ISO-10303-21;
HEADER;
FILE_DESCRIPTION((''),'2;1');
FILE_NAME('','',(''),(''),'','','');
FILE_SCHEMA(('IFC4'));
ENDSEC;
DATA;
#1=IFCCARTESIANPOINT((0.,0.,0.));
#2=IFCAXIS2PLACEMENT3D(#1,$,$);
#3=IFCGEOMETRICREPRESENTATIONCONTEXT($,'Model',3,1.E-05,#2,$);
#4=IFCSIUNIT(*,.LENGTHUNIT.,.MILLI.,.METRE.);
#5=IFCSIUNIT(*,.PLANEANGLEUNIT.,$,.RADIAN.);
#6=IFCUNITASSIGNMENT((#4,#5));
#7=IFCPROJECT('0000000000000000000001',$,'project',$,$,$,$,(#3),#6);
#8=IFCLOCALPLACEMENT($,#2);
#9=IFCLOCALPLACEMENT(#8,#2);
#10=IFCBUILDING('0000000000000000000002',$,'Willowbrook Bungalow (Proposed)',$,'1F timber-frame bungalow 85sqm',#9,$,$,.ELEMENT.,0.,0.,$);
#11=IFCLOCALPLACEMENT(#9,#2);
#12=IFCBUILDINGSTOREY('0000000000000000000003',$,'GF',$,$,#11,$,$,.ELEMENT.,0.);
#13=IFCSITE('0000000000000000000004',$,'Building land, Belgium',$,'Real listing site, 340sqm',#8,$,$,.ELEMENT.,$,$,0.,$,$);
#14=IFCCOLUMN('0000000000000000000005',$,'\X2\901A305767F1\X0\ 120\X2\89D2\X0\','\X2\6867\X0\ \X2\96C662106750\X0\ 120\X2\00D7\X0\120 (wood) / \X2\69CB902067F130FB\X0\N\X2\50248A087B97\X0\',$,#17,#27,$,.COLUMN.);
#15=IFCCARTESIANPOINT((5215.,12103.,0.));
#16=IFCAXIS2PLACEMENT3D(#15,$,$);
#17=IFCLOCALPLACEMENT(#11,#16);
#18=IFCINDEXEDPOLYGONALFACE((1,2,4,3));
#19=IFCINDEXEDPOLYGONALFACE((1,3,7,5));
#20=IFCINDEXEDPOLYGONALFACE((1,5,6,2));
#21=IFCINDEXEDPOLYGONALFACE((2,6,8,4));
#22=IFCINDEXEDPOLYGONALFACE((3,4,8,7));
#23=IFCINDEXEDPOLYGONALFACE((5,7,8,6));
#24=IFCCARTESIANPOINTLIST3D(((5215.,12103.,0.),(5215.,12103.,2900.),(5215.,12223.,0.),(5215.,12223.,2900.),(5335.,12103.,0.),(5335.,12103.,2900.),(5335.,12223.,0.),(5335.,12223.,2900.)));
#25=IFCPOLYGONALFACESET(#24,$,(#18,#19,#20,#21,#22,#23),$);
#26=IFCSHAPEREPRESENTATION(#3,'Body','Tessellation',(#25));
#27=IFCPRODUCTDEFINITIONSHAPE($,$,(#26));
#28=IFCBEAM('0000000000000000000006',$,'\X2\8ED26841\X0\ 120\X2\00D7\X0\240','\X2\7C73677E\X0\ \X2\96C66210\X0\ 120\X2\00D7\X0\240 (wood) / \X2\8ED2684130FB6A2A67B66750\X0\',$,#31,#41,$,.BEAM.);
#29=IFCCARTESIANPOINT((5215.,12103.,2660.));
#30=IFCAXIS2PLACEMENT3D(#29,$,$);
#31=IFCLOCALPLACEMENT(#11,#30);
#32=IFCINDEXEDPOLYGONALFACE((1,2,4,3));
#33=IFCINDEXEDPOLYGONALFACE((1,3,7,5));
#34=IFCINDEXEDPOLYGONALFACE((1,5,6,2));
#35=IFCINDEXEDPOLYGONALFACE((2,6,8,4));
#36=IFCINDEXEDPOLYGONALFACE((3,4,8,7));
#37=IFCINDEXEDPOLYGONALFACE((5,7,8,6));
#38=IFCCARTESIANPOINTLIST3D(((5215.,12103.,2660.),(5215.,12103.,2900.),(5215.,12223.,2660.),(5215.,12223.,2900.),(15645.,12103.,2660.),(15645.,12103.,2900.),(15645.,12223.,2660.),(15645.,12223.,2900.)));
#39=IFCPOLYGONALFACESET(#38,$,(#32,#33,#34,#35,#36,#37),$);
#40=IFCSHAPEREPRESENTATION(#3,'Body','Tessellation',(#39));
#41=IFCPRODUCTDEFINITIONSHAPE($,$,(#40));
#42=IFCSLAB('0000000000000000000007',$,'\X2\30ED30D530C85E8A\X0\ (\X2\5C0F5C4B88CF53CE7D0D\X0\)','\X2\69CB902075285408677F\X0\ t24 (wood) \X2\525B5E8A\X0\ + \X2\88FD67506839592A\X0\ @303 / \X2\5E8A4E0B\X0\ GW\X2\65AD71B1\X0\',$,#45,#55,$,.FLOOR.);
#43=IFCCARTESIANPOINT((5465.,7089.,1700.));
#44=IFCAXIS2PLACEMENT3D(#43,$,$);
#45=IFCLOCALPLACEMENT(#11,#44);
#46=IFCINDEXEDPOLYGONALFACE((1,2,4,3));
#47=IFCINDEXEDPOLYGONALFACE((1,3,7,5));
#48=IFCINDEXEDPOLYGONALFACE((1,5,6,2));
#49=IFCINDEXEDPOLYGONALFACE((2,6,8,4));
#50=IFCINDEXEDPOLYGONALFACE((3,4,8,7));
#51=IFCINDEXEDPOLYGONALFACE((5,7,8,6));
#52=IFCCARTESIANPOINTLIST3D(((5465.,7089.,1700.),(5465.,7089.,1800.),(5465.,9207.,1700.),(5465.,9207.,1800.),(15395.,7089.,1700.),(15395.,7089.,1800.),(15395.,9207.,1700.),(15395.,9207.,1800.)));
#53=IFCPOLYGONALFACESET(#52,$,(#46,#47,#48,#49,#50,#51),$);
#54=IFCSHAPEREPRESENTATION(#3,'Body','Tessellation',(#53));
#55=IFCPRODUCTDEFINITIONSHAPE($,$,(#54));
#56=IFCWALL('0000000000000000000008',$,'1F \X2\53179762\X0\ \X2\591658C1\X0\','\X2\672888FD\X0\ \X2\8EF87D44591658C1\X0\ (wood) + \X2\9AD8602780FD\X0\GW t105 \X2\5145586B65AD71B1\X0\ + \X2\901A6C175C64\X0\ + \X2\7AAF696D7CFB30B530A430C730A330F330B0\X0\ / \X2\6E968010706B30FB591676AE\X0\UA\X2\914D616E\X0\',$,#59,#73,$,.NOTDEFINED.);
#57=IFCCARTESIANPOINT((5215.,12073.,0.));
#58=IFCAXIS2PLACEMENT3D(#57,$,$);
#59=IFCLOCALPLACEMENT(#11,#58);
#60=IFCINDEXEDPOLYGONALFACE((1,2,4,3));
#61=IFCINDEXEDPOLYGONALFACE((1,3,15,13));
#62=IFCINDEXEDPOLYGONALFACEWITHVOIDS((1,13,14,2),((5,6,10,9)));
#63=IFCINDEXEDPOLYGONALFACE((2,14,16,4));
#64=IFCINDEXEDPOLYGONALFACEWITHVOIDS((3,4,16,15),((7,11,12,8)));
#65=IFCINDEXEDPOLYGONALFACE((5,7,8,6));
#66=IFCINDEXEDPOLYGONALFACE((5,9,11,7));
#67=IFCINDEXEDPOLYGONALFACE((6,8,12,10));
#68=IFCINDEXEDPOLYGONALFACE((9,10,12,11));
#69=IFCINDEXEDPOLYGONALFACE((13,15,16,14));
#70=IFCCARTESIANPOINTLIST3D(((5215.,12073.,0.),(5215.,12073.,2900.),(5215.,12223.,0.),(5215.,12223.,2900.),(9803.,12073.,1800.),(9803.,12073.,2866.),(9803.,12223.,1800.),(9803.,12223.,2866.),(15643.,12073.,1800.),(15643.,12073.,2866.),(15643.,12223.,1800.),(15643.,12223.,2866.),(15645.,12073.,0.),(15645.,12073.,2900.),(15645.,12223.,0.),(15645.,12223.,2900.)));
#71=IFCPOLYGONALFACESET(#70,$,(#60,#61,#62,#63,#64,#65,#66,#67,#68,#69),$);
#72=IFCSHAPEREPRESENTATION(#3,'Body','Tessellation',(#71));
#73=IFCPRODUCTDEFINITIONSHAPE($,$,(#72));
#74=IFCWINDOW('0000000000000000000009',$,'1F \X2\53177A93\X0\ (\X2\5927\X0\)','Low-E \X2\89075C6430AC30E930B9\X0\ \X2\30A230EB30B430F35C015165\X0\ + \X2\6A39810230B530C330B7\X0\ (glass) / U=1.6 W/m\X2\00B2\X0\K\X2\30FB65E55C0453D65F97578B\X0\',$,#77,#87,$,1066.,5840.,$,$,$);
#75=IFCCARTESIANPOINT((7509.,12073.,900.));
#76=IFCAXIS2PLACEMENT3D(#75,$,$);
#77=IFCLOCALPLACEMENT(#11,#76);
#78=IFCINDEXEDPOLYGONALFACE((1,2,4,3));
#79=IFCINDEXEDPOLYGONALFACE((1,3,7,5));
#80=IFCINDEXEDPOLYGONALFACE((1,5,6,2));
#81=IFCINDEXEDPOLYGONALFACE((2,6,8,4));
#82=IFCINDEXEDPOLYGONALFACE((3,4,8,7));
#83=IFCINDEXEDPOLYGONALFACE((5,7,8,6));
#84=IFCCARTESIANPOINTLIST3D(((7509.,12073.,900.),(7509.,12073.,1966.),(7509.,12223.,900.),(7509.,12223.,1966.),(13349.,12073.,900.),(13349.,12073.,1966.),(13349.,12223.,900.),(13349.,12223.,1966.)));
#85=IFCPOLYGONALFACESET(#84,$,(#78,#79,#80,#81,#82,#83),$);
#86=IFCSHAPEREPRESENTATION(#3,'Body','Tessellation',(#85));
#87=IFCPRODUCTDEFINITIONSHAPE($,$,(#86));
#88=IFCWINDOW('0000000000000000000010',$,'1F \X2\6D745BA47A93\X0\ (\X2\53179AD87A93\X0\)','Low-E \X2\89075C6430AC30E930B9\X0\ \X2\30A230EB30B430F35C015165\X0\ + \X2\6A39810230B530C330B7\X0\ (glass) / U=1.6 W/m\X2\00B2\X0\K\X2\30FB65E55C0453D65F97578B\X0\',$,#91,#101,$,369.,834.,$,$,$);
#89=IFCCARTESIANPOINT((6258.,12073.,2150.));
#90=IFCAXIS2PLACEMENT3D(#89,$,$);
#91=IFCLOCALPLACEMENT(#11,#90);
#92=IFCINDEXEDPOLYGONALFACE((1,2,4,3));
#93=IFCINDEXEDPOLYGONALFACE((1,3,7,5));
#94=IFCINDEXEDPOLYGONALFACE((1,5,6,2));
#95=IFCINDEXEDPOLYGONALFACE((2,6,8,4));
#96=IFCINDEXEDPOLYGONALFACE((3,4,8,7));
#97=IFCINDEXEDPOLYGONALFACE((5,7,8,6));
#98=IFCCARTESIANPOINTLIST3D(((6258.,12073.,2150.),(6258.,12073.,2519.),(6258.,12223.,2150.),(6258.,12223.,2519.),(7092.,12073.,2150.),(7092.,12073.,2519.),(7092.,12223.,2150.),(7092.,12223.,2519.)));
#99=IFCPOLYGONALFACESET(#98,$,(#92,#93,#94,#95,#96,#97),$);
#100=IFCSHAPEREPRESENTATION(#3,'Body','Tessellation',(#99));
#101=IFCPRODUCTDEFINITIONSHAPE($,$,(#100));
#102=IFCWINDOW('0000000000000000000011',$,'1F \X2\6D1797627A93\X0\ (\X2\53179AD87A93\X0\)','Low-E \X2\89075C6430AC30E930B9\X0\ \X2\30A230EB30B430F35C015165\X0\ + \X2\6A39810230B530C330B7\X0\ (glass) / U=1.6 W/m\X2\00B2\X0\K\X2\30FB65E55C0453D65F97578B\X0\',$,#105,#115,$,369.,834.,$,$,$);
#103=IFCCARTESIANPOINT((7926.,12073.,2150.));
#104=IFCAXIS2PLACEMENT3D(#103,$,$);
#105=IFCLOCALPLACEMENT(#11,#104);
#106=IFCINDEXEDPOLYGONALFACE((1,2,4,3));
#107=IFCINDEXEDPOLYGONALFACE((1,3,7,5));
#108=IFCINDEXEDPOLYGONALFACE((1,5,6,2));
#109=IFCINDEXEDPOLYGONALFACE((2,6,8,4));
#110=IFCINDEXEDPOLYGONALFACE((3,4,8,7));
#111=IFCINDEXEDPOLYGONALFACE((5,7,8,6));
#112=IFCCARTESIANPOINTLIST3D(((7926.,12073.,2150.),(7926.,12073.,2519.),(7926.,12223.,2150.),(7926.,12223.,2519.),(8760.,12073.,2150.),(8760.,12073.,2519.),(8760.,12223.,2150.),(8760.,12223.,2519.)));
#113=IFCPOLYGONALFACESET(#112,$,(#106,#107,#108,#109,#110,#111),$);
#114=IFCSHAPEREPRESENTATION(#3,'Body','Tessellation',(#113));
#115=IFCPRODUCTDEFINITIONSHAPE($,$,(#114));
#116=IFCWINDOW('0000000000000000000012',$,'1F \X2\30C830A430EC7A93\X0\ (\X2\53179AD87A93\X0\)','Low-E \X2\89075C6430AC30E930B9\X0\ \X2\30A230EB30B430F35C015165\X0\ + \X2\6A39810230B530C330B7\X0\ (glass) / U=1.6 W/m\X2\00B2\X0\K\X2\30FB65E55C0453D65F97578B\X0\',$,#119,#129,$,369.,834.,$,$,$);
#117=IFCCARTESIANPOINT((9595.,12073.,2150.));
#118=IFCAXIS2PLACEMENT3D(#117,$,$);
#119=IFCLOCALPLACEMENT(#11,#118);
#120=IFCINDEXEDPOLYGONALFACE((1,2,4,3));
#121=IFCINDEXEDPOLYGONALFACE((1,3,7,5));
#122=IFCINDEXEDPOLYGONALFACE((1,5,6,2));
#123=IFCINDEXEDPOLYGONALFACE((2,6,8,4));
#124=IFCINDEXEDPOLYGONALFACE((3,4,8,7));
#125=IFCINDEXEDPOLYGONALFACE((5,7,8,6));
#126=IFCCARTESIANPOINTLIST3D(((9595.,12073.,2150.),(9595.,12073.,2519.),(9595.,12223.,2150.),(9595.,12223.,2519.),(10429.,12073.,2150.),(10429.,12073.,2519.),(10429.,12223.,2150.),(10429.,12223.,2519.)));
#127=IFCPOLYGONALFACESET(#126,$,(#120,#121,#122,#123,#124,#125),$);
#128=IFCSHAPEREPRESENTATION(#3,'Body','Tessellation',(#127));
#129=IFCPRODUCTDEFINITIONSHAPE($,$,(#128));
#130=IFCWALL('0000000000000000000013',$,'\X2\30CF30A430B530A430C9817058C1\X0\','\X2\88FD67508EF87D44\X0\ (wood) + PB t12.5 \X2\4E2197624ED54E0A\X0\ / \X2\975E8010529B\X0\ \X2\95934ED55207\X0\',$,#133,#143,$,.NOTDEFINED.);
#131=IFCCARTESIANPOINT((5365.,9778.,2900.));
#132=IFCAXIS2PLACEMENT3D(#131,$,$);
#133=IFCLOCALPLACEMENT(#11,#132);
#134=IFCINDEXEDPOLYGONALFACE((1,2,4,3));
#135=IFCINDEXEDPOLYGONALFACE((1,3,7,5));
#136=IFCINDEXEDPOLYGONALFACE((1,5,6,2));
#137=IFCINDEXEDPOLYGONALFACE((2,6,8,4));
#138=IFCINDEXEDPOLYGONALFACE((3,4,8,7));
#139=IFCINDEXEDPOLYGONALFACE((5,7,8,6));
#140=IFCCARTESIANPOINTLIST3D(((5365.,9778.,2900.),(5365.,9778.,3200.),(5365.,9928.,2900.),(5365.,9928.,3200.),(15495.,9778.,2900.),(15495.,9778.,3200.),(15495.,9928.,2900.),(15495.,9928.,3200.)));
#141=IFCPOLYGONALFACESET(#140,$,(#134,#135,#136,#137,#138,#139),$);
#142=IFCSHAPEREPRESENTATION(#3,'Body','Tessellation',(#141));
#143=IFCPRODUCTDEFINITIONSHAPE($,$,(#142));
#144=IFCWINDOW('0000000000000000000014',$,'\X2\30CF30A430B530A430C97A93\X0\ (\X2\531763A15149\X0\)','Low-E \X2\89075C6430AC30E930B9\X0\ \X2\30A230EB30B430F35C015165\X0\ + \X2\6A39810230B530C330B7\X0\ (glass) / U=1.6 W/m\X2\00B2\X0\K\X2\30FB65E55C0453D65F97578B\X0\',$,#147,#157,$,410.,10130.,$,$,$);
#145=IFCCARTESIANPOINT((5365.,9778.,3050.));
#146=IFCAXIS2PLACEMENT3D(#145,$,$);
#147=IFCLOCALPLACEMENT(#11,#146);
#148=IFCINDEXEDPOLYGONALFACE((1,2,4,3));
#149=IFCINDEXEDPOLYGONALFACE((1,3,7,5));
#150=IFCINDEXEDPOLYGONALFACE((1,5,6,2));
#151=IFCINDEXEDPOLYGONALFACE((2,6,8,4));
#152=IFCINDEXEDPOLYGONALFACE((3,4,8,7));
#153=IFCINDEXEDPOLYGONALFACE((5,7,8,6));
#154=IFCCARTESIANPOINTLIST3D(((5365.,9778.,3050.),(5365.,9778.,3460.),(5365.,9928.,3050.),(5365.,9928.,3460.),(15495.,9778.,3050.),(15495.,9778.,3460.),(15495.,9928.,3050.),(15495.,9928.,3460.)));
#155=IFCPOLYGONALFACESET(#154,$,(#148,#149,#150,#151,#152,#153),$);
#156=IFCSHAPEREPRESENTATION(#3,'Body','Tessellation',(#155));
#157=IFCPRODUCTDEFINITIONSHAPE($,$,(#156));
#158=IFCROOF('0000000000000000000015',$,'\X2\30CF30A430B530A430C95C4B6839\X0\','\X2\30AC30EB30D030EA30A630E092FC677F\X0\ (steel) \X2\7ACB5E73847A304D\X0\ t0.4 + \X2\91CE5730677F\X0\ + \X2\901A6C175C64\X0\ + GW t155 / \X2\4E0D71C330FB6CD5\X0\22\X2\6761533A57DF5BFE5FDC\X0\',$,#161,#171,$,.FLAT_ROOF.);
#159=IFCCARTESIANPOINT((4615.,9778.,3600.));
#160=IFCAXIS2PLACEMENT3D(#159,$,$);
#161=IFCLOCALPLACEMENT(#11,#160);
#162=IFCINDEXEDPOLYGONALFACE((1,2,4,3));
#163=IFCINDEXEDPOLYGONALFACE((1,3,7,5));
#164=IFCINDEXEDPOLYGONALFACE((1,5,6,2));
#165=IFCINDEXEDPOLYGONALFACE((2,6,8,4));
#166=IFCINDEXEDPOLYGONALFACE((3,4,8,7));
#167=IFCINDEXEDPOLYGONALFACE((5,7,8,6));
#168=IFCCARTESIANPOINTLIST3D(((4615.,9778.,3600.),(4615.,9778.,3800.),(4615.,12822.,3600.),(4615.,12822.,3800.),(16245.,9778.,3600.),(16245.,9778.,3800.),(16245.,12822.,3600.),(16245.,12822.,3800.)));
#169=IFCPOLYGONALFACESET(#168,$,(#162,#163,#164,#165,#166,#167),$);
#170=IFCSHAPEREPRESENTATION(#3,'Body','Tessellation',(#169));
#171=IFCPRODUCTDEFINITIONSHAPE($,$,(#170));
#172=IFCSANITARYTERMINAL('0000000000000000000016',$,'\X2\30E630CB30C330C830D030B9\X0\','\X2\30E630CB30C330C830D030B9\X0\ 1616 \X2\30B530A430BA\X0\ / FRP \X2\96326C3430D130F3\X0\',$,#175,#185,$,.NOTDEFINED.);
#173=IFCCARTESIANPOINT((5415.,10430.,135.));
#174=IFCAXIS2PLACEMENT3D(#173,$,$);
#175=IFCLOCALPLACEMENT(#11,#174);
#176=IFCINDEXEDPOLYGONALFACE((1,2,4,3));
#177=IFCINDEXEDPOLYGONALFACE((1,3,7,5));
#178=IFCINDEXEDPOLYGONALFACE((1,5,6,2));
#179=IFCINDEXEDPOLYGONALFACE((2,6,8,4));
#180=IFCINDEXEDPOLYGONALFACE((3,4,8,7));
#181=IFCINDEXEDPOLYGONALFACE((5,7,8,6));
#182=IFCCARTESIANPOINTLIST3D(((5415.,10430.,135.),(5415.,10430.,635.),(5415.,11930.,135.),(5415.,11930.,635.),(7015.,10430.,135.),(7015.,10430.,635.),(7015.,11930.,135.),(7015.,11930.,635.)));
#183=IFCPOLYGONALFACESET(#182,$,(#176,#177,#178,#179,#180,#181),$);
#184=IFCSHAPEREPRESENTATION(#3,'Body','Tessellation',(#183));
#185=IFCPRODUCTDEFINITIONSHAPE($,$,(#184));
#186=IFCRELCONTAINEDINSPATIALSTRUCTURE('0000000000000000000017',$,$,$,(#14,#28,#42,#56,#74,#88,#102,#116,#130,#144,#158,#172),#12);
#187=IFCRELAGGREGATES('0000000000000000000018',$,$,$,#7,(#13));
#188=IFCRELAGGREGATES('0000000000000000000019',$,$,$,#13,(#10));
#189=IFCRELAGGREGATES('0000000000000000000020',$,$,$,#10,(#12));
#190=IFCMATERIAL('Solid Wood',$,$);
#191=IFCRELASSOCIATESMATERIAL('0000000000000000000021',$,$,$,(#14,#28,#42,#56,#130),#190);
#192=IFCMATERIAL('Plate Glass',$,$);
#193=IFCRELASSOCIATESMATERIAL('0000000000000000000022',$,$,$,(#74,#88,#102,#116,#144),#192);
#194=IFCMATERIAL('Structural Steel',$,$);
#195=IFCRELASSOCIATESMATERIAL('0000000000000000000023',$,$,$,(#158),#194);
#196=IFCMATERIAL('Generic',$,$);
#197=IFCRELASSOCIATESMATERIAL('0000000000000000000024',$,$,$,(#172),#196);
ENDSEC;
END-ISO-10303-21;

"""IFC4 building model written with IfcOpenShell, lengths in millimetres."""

from ifc_helpers import new_model, si_unit, frame, frame_2d, origin, place, context, project, spatial, rectangle, extrude, material, element, fill, save


model = new_model("IFC4")

# Units and contexts
model_context = context("Model", 3, precision=1e-05, world=origin())
ifc_project = project(units=[si_unit("LENGTHUNIT", "METRE", prefix="MILLI"), si_unit("PLANEANGLEUNIT", "RADIAN")], contexts=[model_context])

# Site, building, storey
site_placement = place(None, origin())
site = spatial("IfcSite", under=ifc_project, at=site_placement, Name="Building land, Belgium", ObjectType="Real listing site, 340sqm", CompositionType="ELEMENT", RefElevation=0.0)
building_placement = place(site_placement, origin())
building = spatial("IfcBuilding", under=site, at=building_placement, Name="Willowbrook Bungalow (Proposed)", ObjectType="1F timber-frame bungalow 85sqm", CompositionType="ELEMENT", ElevationOfRefHeight=0.0, ElevationOfTerrain=0.0)
storey_placement = place(building_placement, origin())
storey = spatial("IfcBuildingStorey", under=building, at=storey_placement, Name="GF", CompositionType="ELEMENT", Elevation=0.0)

# Column
ifc_material_1 = material(Name="Solid Wood")
column_1_placement = place(storey_placement, frame((5215.0, 12103.0, 0.0)))
element("IfcColumn", 1, at=column_1_placement, inside=storey, material=ifc_material_1, Name="通し柱 120角", Description="桧 集成材 120×120 (wood) / 構造柱・N値計算", PredefinedType="COLUMN", context=model_context, shape_type="SweptSolid", body=[
    extrude(rectangle(XDim=120.0, YDim=120.0, at=frame_2d((60.0, 60.0))), frame((5215.0, 12103.0, 0.0)), (0.0, 0.0, 1.0), 2900.0),
])

# Beam
beam_1_placement = place(storey_placement, frame((5215.0, 12103.0, 2660.0)))
element("IfcBeam", 2, at=beam_1_placement, inside=storey, material=ifc_material_1, Name="軒桁 120×240", Description="米松 集成 120×240 (wood) / 軒桁・横架材", PredefinedType="BEAM", context=model_context, shape_type="SweptSolid", body=[
    extrude(rectangle(XDim=10430.0, YDim=120.0, at=frame_2d((5215.0, 60.0))), frame((5215.0, 12103.0, 2660.0)), (0.0, 0.0, 1.0), 240.0),
])

# Slab
slab_placement = place(storey_placement, frame((5465.0, 7089.0, 1700.0)))
element("IfcSlab", 3, at=slab_placement, inside=storey, material=ifc_material_1, Name="ロフト床 (小屋裏収納)", Description="構造用合板 t24 (wood) 剛床 + 製材根太 @303 / 床下 GW断熱", PredefinedType="FLOOR", context=model_context, shape_type="SweptSolid", body=[
    extrude(rectangle(XDim=9930.0, YDim=2118.0, at=frame_2d((4965.0, 1059.0))), frame((5465.0, 7089.0, 1700.0)), (0.0, 0.0, 1.0), 100.0),
])

# Wall, openings, windows
wall_1_placement = place(storey_placement, frame((5215.0, 12073.0, 0.0)))
wall_1 = element("IfcWall", 4, at=wall_1_placement, inside=storey, material=ifc_material_1, Name="1F 北面 外壁", Description="木製 軸組外壁 (wood) + 高性能GW t105 充填断熱 + 通気層 + 窯業系サイディング / 準耐火・外皮UA配慮", PredefinedType="NOTDEFINED", context=model_context, shape_type="SweptSolid", body=[
    extrude(rectangle(XDim=10430.0, YDim=150.0, at=frame_2d((5215.0, 75.0))), frame((5215.0, 12073.0, 0.0)), (0.0, 0.0, 1.0), 2900.0),
])
opening_1_placement = place(storey_placement, frame((7509.0, 12073.0, 900.0)))
opening_1 = element("IfcOpeningElement", 5, at=opening_1_placement, cuts=wall_1, PredefinedType="NOTDEFINED", context=model_context, shape_type="SweptSolid", body=[
    extrude(rectangle(XDim=5840.0, YDim=150.0, at=frame_2d((2920.0, 75.0))), frame((7509.0, 12073.0, 900.0)), (0.0, 0.0, 1.0), 1066.0),
])
opening_2_placement = place(storey_placement, frame((6258.0, 12073.0, 2150.0)))
opening_2 = element("IfcOpeningElement", 6, at=opening_2_placement, cuts=wall_1, PredefinedType="NOTDEFINED", context=model_context, shape_type="SweptSolid", body=[
    extrude(rectangle(XDim=834.0, YDim=150.0, at=frame_2d((417.0, 75.0))), frame((6258.0, 12073.0, 2150.0)), (0.0, 0.0, 1.0), 369.0),
])
opening_3_placement = place(storey_placement, frame((7926.0, 12073.0, 2150.0)))
opening_3 = element("IfcOpeningElement", 7, at=opening_3_placement, cuts=wall_1, PredefinedType="NOTDEFINED", context=model_context, shape_type="SweptSolid", body=[
    extrude(rectangle(XDim=834.0, YDim=150.0, at=frame_2d((417.0, 75.0))), frame((7926.0, 12073.0, 2150.0)), (0.0, 0.0, 1.0), 369.0),
])
opening_4_placement = place(storey_placement, frame((9595.0, 12073.0, 2150.0)))
opening_4 = element("IfcOpeningElement", 8, at=opening_4_placement, cuts=wall_1, PredefinedType="NOTDEFINED", context=model_context, shape_type="SweptSolid", body=[
    extrude(rectangle(XDim=834.0, YDim=150.0, at=frame_2d((417.0, 75.0))), frame((9595.0, 12073.0, 2150.0)), (0.0, 0.0, 1.0), 369.0),
])
ifc_material_2 = material(Name="Plate Glass")
window_1_placement = place(storey_placement, frame((7509.0, 12073.0, 900.0)))
window_1 = element("IfcWindow", 9, at=window_1_placement, inside=storey, material=ifc_material_2, Name="1F 北窓 (大)", Description="Low-E 複層ガラス アルゴン封入 + 樹脂サッシ (glass) / U=1.6 W/m²K・日射取得型", OverallHeight=1066.0, OverallWidth=5840.0, context=model_context, shape_type="SweptSolid", body=[
    extrude(rectangle(XDim=5840.0, YDim=150.0, at=frame_2d((2920.0, 75.0))), frame((7509.0, 12073.0, 900.0)), (0.0, 0.0, 1.0), 1066.0),
])
fill(opening_1, window_1)
window_2_placement = place(storey_placement, frame((6258.0, 12073.0, 2150.0)))
window_2 = element("IfcWindow", 10, at=window_2_placement, inside=storey, material=ifc_material_2, Name="1F 浴室窓 (北高窓)", Description="Low-E 複層ガラス アルゴン封入 + 樹脂サッシ (glass) / U=1.6 W/m²K・日射取得型", OverallHeight=369.0, OverallWidth=834.0, context=model_context, shape_type="SweptSolid", body=[
    extrude(rectangle(XDim=834.0, YDim=150.0, at=frame_2d((417.0, 75.0))), frame((6258.0, 12073.0, 2150.0)), (0.0, 0.0, 1.0), 369.0),
])
fill(opening_2, window_2)
window_3_placement = place(storey_placement, frame((7926.0, 12073.0, 2150.0)))
window_3 = element("IfcWindow", 11, at=window_3_placement, inside=storey, material=ifc_material_2, Name="1F 洗面窓 (北高窓)", Description="Low-E 複層ガラス アルゴン封入 + 樹脂サッシ (glass) / U=1.6 W/m²K・日射取得型", OverallHeight=369.0, OverallWidth=834.0, context=model_context, shape_type="SweptSolid", body=[
    extrude(rectangle(XDim=834.0, YDim=150.0, at=frame_2d((417.0, 75.0))), frame((7926.0, 12073.0, 2150.0)), (0.0, 0.0, 1.0), 369.0),
])
fill(opening_3, window_3)
window_4_placement = place(storey_placement, frame((9595.0, 12073.0, 2150.0)))
window_4 = element("IfcWindow", 12, at=window_4_placement, inside=storey, material=ifc_material_2, Name="1F トイレ窓 (北高窓)", Description="Low-E 複層ガラス アルゴン封入 + 樹脂サッシ (glass) / U=1.6 W/m²K・日射取得型", OverallHeight=369.0, OverallWidth=834.0, context=model_context, shape_type="SweptSolid", body=[
    extrude(rectangle(XDim=834.0, YDim=150.0, at=frame_2d((417.0, 75.0))), frame((9595.0, 12073.0, 2150.0)), (0.0, 0.0, 1.0), 369.0),
])
fill(opening_4, window_4)

# Wall, opening, window
wall_2_placement = place(storey_placement, frame((5365.0, 9778.0, 2900.0)))
wall_2 = element("IfcWall", 13, at=wall_2_placement, inside=storey, material=ifc_material_1, Name="ハイサイド腰壁", Description="製材軸組 (wood) + PB t12.5 両面仕上 / 非耐力 間仕切", PredefinedType="NOTDEFINED", context=model_context, shape_type="SweptSolid", body=[
    extrude(rectangle(XDim=10130.0, YDim=150.0, at=frame_2d((5065.0, 75.0))), frame((5365.0, 9778.0, 2900.0)), (0.0, 0.0, 1.0), 700.0),
])
opening_5_placement = place(storey_placement, frame((5365.0, 9778.0, 3050.0)))
opening_5 = element("IfcOpeningElement", 14, at=opening_5_placement, cuts=wall_2, PredefinedType="NOTDEFINED", context=model_context, shape_type="SweptSolid", body=[
    extrude(rectangle(XDim=10130.0, YDim=150.0, at=frame_2d((5065.0, 75.0))), frame((5365.0, 9778.0, 3050.0)), (0.0, 0.0, 1.0), 410.0),
])
window_5_placement = place(storey_placement, frame((5365.0, 9778.0, 3050.0)))
window_5 = element("IfcWindow", 15, at=window_5_placement, inside=storey, material=ifc_material_2, Name="ハイサイド窓 (北採光)", Description="Low-E 複層ガラス アルゴン封入 + 樹脂サッシ (glass) / U=1.6 W/m²K・日射取得型", OverallHeight=410.0, OverallWidth=10130.0, context=model_context, shape_type="SweptSolid", body=[
    extrude(rectangle(XDim=10130.0, YDim=150.0, at=frame_2d((5065.0, 75.0))), frame((5365.0, 9778.0, 3050.0)), (0.0, 0.0, 1.0), 410.0),
])
fill(opening_5, window_5)

# Roof
ifc_material_3 = material(Name="Structural Steel")
roof_placement = place(storey_placement, frame((4615.0, 9778.0, 3600.0)))
element("IfcRoof", 16, at=roof_placement, inside=storey, material=ifc_material_3, Name="ハイサイド屋根", Description="ガルバリウム鋼板 (steel) 立平葺き t0.4 + 野地板 + 通気層 + GW t155 / 不燃・法22条区域対応", PredefinedType="FLAT_ROOF", context=model_context, shape_type="SweptSolid", body=[
    extrude(rectangle(XDim=11630.0, YDim=3044.0, at=frame_2d((5815.0, 1522.0))), frame((4615.0, 9778.0, 3600.0)), (0.0, 0.0, 1.0), 200.0),
])

# Sanitary terminal
ifc_material_4 = material(Name="Generic")
sanitary_terminal_placement = place(storey_placement, frame((5415.0, 10430.0, 135.0)))
element("IfcSanitaryTerminal", 17, at=sanitary_terminal_placement, inside=storey, material=ifc_material_4, Name="ユニットバス", Description="ユニットバス 1616 サイズ / FRP 防水パン", PredefinedType="NOTDEFINED", context=model_context, shape_type="SweptSolid", body=[
    extrude(rectangle(XDim=1600.0, YDim=1500.0, at=frame_2d((800.0, 750.0))), frame((5415.0, 10430.0, 135.0)), (0.0, 0.0, 1.0), 500.0),
])

save(model, "model.ifc")
